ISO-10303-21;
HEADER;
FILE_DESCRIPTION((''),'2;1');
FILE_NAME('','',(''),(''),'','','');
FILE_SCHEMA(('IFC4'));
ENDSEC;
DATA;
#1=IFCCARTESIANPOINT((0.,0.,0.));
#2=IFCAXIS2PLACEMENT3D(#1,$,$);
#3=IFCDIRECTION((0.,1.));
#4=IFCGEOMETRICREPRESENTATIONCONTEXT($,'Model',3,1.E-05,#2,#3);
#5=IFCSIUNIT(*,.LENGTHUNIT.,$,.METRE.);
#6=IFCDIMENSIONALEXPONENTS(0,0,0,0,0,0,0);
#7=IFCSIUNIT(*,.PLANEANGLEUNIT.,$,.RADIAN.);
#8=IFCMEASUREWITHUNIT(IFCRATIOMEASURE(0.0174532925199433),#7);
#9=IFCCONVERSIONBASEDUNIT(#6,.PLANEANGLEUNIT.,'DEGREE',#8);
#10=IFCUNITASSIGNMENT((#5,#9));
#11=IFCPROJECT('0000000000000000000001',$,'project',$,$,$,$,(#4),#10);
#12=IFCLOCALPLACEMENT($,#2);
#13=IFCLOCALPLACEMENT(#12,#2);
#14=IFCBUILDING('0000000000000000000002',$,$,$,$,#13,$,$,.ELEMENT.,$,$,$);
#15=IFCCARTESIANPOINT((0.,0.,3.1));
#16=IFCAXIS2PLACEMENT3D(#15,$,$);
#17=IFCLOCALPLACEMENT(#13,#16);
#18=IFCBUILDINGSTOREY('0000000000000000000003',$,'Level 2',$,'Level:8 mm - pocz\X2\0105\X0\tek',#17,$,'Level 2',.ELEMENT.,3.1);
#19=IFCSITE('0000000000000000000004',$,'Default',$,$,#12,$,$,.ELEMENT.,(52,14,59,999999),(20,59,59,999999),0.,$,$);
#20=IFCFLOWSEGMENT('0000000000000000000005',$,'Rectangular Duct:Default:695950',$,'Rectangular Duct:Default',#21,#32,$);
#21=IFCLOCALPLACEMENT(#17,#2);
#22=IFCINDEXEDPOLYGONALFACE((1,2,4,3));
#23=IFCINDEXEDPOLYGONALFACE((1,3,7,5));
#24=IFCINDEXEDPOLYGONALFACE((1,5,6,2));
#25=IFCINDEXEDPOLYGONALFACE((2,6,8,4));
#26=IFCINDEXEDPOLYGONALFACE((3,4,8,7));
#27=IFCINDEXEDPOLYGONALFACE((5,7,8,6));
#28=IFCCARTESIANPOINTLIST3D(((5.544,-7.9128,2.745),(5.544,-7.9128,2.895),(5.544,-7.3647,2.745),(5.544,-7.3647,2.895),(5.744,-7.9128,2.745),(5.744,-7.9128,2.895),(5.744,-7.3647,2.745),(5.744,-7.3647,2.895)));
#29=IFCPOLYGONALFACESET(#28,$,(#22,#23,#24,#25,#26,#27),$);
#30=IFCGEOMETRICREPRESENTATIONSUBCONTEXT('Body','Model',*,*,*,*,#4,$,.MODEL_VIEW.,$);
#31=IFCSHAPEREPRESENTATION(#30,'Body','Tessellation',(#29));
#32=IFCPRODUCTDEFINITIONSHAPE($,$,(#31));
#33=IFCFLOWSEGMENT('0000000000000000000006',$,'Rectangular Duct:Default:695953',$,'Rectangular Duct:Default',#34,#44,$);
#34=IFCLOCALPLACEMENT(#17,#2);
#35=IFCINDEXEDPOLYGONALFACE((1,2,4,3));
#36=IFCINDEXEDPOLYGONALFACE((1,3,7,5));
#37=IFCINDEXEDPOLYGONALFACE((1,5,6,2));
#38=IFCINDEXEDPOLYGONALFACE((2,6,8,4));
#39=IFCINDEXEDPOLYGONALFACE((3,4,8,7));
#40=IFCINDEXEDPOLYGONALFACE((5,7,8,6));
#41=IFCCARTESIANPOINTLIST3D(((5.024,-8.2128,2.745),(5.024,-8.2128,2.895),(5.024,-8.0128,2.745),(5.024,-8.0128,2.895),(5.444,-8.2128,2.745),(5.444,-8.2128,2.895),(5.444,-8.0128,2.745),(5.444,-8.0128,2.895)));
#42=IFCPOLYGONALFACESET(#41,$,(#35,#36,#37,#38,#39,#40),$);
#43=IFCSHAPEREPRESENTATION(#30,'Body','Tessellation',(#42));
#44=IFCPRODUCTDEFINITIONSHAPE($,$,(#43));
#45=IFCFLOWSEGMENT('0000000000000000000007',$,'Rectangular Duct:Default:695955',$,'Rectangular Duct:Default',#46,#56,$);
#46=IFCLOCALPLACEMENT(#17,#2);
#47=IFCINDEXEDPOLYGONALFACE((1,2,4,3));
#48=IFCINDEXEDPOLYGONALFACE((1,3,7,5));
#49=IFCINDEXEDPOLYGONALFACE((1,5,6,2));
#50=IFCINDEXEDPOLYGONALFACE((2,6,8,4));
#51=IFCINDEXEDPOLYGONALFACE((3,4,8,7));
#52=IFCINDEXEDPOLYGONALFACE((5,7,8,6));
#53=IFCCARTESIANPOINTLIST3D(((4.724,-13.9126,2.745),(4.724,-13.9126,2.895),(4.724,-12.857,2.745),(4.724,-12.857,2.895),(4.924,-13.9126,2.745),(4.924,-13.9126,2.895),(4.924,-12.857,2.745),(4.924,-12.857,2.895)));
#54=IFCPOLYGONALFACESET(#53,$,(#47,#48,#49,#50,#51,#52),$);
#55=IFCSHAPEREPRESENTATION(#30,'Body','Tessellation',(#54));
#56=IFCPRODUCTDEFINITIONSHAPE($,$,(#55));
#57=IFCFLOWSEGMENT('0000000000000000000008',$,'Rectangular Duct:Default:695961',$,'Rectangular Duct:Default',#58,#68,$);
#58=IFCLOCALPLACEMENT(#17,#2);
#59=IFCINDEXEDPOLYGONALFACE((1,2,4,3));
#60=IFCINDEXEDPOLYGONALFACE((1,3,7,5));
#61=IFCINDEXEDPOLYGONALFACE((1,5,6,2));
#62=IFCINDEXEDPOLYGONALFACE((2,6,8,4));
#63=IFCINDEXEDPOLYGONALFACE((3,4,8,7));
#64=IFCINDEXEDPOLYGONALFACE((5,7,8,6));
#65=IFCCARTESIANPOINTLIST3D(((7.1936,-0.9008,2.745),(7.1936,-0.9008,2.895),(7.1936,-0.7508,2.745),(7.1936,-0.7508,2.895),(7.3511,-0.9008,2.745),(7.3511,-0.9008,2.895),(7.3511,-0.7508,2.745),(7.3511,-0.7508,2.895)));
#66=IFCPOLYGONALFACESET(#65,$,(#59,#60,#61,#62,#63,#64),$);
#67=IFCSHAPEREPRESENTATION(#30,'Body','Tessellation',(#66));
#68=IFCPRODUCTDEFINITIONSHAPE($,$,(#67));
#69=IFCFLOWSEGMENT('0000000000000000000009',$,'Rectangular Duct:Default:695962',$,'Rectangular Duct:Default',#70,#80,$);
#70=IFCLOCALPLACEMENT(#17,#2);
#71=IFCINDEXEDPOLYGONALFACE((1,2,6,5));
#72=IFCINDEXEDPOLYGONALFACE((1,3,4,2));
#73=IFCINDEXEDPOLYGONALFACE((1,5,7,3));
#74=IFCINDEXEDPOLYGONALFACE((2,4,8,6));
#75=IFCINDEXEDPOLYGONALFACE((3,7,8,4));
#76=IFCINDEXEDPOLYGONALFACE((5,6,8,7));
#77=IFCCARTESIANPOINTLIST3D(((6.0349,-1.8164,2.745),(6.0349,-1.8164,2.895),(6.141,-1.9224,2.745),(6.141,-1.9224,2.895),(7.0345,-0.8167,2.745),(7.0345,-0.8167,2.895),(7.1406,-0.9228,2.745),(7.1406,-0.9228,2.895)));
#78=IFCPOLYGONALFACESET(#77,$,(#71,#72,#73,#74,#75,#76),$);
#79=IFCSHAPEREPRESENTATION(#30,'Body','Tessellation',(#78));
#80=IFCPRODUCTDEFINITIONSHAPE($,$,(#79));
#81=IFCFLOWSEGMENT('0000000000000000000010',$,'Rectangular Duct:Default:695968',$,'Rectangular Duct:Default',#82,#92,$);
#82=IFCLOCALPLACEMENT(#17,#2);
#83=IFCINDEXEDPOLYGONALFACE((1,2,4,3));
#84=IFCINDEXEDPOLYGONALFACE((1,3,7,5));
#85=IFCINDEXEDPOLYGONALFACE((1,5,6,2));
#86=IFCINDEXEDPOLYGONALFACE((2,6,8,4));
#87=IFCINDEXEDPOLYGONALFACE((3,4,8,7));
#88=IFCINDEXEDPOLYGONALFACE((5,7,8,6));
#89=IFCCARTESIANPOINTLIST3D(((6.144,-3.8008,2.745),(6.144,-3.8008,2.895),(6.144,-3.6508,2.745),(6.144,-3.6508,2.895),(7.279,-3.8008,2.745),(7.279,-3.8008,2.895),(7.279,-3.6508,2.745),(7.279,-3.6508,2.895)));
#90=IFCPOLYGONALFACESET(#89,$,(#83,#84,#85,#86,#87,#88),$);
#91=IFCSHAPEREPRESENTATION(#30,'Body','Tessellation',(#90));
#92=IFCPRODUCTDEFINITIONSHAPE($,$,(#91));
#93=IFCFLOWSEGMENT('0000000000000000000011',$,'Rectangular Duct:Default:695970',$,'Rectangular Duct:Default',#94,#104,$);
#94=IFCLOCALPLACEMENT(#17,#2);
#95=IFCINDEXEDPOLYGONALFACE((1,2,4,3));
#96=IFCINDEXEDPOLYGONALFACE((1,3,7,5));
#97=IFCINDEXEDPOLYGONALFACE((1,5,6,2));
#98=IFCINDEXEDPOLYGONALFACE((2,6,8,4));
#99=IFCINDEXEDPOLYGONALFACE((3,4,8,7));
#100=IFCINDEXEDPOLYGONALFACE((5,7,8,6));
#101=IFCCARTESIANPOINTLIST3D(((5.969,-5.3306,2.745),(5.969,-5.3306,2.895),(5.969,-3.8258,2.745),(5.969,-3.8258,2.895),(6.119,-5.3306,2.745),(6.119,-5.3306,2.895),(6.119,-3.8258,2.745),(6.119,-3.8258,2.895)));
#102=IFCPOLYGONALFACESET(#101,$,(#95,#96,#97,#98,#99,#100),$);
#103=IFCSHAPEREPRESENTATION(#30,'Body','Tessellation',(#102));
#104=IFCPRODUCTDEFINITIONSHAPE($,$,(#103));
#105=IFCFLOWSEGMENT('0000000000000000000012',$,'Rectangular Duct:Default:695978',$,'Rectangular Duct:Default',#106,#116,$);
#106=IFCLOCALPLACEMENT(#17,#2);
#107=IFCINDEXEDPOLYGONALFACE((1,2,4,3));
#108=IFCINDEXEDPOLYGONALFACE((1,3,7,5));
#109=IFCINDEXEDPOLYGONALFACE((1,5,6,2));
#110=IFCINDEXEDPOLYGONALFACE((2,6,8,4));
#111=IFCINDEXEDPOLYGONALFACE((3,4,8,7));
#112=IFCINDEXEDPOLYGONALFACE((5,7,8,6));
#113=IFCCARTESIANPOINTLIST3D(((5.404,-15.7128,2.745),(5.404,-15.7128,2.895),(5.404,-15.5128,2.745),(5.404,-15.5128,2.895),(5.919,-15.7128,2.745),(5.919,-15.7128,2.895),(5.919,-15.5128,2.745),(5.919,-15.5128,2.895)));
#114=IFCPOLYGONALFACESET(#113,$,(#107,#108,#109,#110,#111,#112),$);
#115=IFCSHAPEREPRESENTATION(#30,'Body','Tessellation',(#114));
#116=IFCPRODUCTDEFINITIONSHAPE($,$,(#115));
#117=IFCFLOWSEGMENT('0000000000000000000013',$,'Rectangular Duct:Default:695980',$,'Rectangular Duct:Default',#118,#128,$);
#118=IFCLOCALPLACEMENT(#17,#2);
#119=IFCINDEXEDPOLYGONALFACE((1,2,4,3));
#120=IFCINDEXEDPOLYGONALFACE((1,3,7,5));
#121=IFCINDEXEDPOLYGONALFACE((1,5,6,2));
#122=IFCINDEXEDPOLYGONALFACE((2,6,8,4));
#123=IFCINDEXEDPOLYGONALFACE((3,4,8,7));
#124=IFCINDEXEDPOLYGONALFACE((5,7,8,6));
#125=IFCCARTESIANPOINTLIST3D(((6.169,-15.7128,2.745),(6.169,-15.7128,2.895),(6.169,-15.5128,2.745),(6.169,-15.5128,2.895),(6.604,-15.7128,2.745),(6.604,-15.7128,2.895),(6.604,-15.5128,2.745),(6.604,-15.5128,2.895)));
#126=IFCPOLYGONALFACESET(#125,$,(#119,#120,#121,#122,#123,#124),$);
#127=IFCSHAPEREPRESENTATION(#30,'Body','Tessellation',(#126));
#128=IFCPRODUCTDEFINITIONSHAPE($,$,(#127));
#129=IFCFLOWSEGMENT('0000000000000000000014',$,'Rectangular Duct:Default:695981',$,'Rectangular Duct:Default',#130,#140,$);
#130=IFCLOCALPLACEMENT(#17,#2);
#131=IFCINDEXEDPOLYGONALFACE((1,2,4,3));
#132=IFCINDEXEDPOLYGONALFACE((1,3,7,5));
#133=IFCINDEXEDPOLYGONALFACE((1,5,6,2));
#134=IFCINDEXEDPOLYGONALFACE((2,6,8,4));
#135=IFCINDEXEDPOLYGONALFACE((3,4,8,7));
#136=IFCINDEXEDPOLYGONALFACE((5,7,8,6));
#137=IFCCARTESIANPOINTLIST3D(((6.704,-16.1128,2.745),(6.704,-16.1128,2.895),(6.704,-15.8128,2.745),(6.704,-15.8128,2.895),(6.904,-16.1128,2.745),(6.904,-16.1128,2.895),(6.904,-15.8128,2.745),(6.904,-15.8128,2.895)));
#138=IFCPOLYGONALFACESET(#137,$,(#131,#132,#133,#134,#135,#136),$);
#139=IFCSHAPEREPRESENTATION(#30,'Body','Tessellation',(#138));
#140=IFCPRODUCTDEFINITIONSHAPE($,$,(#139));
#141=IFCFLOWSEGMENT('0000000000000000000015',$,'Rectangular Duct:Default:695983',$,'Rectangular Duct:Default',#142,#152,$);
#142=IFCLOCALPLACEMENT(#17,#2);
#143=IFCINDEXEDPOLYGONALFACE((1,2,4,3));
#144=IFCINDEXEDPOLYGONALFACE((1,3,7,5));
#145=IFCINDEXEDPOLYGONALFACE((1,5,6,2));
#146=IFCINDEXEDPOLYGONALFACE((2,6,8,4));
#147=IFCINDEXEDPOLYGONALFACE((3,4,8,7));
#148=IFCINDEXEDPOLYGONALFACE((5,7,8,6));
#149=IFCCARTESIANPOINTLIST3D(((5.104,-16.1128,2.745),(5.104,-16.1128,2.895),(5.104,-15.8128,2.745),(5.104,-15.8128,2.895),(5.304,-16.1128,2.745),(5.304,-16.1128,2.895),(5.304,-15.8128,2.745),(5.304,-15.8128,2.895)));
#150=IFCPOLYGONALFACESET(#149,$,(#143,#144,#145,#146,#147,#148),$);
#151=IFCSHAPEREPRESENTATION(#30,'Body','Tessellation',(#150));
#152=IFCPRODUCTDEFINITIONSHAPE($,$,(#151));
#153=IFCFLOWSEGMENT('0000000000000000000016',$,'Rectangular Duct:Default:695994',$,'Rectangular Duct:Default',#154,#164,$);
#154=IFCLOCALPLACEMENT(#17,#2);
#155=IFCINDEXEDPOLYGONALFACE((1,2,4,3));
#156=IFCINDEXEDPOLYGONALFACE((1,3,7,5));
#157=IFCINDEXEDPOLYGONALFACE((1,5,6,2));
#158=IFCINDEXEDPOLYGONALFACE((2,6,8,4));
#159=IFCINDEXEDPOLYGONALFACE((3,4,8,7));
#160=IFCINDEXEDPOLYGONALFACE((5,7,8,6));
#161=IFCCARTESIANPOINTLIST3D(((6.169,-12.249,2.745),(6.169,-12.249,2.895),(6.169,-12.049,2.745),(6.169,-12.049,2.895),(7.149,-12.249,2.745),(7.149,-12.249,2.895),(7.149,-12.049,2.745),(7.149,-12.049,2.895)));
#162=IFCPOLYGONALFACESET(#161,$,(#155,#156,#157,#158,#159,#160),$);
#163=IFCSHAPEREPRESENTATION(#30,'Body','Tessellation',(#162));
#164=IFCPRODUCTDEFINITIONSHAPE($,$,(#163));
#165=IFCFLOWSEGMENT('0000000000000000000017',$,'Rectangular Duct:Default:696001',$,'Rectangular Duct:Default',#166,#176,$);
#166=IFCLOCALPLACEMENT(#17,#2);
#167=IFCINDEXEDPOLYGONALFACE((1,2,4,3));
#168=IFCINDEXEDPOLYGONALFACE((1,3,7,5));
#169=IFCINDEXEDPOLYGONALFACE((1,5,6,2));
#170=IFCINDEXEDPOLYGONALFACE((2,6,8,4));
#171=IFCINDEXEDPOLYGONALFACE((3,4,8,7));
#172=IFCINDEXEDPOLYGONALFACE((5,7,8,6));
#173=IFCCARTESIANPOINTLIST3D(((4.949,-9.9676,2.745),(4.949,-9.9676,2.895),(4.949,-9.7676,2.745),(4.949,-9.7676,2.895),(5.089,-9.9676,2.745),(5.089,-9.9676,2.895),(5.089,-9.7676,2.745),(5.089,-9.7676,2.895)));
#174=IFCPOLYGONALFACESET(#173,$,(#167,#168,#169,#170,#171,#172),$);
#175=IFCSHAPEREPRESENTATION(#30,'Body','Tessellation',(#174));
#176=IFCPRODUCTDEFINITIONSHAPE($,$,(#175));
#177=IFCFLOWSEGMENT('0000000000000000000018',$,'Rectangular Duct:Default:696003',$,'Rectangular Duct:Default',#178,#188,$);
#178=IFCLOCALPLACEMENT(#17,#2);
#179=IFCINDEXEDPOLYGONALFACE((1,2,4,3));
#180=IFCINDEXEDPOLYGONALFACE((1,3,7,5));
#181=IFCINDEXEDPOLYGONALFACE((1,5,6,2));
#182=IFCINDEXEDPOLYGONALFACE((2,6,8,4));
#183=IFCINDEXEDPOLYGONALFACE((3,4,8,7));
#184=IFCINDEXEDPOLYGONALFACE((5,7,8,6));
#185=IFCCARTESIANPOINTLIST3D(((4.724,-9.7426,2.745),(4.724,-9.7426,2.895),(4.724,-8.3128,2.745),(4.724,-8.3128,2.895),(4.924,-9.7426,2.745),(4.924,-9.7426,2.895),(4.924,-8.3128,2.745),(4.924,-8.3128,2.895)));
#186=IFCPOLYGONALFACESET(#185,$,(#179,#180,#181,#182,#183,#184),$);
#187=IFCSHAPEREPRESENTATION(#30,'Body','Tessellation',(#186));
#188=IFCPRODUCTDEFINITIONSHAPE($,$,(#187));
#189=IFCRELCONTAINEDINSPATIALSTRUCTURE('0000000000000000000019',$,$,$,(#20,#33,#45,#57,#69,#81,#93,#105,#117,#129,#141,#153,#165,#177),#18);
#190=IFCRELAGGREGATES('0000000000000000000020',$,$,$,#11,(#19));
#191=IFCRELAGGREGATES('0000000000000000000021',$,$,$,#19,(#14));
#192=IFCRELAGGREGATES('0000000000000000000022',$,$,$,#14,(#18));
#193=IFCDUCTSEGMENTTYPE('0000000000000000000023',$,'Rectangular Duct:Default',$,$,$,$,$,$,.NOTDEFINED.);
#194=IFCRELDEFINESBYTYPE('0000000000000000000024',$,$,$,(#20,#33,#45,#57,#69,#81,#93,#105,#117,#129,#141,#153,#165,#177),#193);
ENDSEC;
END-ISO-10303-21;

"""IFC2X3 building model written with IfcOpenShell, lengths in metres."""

from ifc_helpers import new_model, entity, si_unit, converted_unit, direction, frame, frame_2d, origin, origin_2d_with_axis, place, context, subcontext, project, spatial, rectangle, extrude, type_object, element, save


model = new_model("IFC2X3")

# Units and contexts
model_context = context("Model", 3, precision=1e-05, world=origin(), true_north=direction((0.0, 1.0)))
body_context = subcontext(model_context, "Body", "Model", "MODEL_VIEW")
ifc_project = project(units=[si_unit("LENGTHUNIT", "METRE"), converted_unit("PLANEANGLEUNIT", "DEGREE", entity("IfcRatioMeasure", 0.0174532925199433), si_unit("PLANEANGLEUNIT", "RADIAN"), dimensions=[0, 0, 0, 0, 0, 0, 0])], contexts=[model_context])

# Site, building, storey
site_placement = place(None, origin())
site = spatial("IfcSite", under=ifc_project, at=site_placement, Name="Default", CompositionType="ELEMENT", RefLatitude=(52, 14, 59, 999999), RefLongitude=(20, 59, 59, 999999), RefElevation=0.0)
building_placement = place(site_placement, origin())
building = spatial("IfcBuilding", under=site, at=building_placement, CompositionType="ELEMENT")
storey_placement = place(building_placement, frame((0.0, 0.0, 3.1)))
storey = spatial("IfcBuildingStorey", under=building, at=storey_placement, Name="Level 2", ObjectType="Level:8 mm - początek", LongName="Level 2", CompositionType="ELEMENT", Elevation=3.1)

# Flow segments
duct_segment_type = type_object("IfcDuctSegmentType", Name="Rectangular Duct:Default", PredefinedType="NOTDEFINED")
flow_segment_1_placement = place(storey_placement, origin())
element("IfcFlowSegment", 1, at=flow_segment_1_placement, inside=storey, type_object=duct_segment_type, Name="Rectangular Duct:Default:695950", ObjectType="Rectangular Duct:Default", context=body_context, shape_type="SweptSolid", body=[
    extrude(rectangle(XDim=0.5481, YDim=0.2, at=frame_2d((0.0, 0.0), x_axis=(1.0, 0.0))), frame((5.644, -7.6388, 2.745), z_axis=(0.0, 0.0, 1.0), x_axis=(0.0, -1.0, 0.0)), (0.0, 0.0, 1.0), 0.15),
])
flow_segment_2_placement = place(storey_placement, origin())
element("IfcFlowSegment", 2, at=flow_segment_2_placement, inside=storey, type_object=duct_segment_type, Name="Rectangular Duct:Default:695953", ObjectType="Rectangular Duct:Default", context=body_context, shape_type="SweptSolid", body=[
    extrude(rectangle(XDim=0.42, YDim=0.2, at=origin_2d_with_axis()), frame((5.234, -8.1128, 2.745), z_axis=(0.0, 0.0, 1.0), x_axis=(-1.0, 0.0, 0.0)), (0.0, 0.0, 1.0), 0.15),
])
flow_segment_3_placement = place(storey_placement, origin())
element("IfcFlowSegment", 3, at=flow_segment_3_placement, inside=storey, type_object=duct_segment_type, Name="Rectangular Duct:Default:695955", ObjectType="Rectangular Duct:Default", context=body_context, shape_type="SweptSolid", body=[
    extrude(rectangle(XDim=1.0556, YDim=0.2, at=frame_2d((0.0, 0.0), x_axis=(1.0, 0.0))), frame((4.824, -13.3848, 2.745), z_axis=(0.0, 0.0, 1.0), x_axis=(0.0, -1.0, 0.0)), (0.0, 0.0, 1.0), 0.15),
])
flow_segment_4_placement = place(storey_placement, origin())
element("IfcFlowSegment", 4, at=flow_segment_4_placement, inside=storey, type_object=duct_segment_type, Name="Rectangular Duct:Default:695961", ObjectType="Rectangular Duct:Default", context=body_context, shape_type="SweptSolid", body=[
    extrude(rectangle(XDim=0.1575, YDim=0.15, at=frame_2d((0.0, 0.0), x_axis=(1.0, 0.0))), frame((7.2724, -0.8258, 2.745)), (0.0, 0.0, 1.0), 0.15),
])
flow_segment_5_placement = place(storey_placement, origin())
element("IfcFlowSegment", 5, at=flow_segment_5_placement, inside=storey, type_object=duct_segment_type, Name="Rectangular Duct:Default:695962", ObjectType="Rectangular Duct:Default", context=body_context, shape_type="SweptSolid", body=[
    extrude(rectangle(XDim=1.4137, YDim=0.15, at=frame_2d((0.0, 0.0), x_axis=(1.0, 0.0))), frame((6.5877, -1.3696, 2.745), z_axis=(0.0, 0.0, 1.0), x_axis=(0.707107, 0.707107, 0.0)), (0.0, 0.0, 1.0), 0.15),
])
flow_segment_6_placement = place(storey_placement, origin())
element("IfcFlowSegment", 6, at=flow_segment_6_placement, inside=storey, type_object=duct_segment_type, Name="Rectangular Duct:Default:695968", ObjectType="Rectangular Duct:Default", context=body_context, shape_type="SweptSolid", body=[
    extrude(rectangle(XDim=1.135, YDim=0.15, at=frame_2d((0.0, 0.0), x_axis=(1.0, 0.0))), frame((6.7115, -3.7258, 2.745)), (0.0, 0.0, 1.0), 0.15),
])
flow_segment_7_placement = place(storey_placement, origin())
element("IfcFlowSegment", 7, at=flow_segment_7_placement, inside=storey, type_object=duct_segment_type, Name="Rectangular Duct:Default:695970", ObjectType="Rectangular Duct:Default", context=body_context, shape_type="SweptSolid", body=[
    extrude(rectangle(XDim=1.5048, YDim=0.15, at=frame_2d((0.0, 0.0), x_axis=(1.0, 0.0))), frame((6.044, -4.5782, 2.745), z_axis=(0.0, 0.0, 1.0), x_axis=(0.0, 1.0, 0.0)), (0.0, 0.0, 1.0), 0.15),
])
flow_segment_8_placement = place(storey_placement, origin())
element("IfcFlowSegment", 8, at=flow_segment_8_placement, inside=storey, type_object=duct_segment_type, Name="Rectangular Duct:Default:695978", ObjectType="Rectangular Duct:Default", context=body_context, shape_type="SweptSolid", body=[
    extrude(rectangle(XDim=0.515, YDim=0.2, at=frame_2d((0.0, 0.0), x_axis=(1.0, 0.0))), frame((5.6615, -15.6128, 2.745), z_axis=(0.0, 0.0, 1.0), x_axis=(-1.0, 0.0, 0.0)), (0.0, 0.0, 1.0), 0.15),
])
flow_segment_9_placement = place(storey_placement, origin())
element("IfcFlowSegment", 9, at=flow_segment_9_placement, inside=storey, type_object=duct_segment_type, Name="Rectangular Duct:Default:695980", ObjectType="Rectangular Duct:Default", context=body_context, shape_type="SweptSolid", body=[
    extrude(rectangle(XDim=0.435, YDim=0.2, at=frame_2d((0.0, 0.0), x_axis=(1.0, 0.0))), frame((6.3865, -15.6128, 2.745), z_axis=(0.0, 0.0, 1.0), x_axis=(-1.0, 0.0, 0.0)), (0.0, 0.0, 1.0), 0.15),
])
flow_segment_10_placement = place(storey_placement, origin())
element("IfcFlowSegment", 10, at=flow_segment_10_placement, inside=storey, type_object=duct_segment_type, Name="Rectangular Duct:Default:695981", ObjectType="Rectangular Duct:Default", context=body_context, shape_type="SweptSolid", body=[
    extrude(rectangle(XDim=0.3, YDim=0.2, at=frame_2d((0.0, 0.0), x_axis=(1.0, 0.0))), frame((6.804, -15.9628, 2.745), z_axis=(0.0, 0.0, 1.0), x_axis=(0.0, -1.0, 0.0)), (0.0, 0.0, 1.0), 0.15),
])
flow_segment_11_placement = place(storey_placement, origin())
element("IfcFlowSegment", 11, at=flow_segment_11_placement, inside=storey, type_object=duct_segment_type, Name="Rectangular Duct:Default:695983", ObjectType="Rectangular Duct:Default", context=body_context, shape_type="SweptSolid", body=[
    extrude(rectangle(XDim=0.3, YDim=0.2, at=frame_2d((0.0, 0.0), x_axis=(1.0, 0.0))), frame((5.204, -15.9628, 2.745), z_axis=(0.0, 0.0, 1.0), x_axis=(0.0, -1.0, 0.0)), (0.0, 0.0, 1.0), 0.15),
])
flow_segment_12_placement = place(storey_placement, origin())
element("IfcFlowSegment", 12, at=flow_segment_12_placement, inside=storey, type_object=duct_segment_type, Name="Rectangular Duct:Default:695994", ObjectType="Rectangular Duct:Default", context=body_context, shape_type="SweptSolid", body=[
    extrude(rectangle(XDim=0.98, YDim=0.2, at=origin_2d_with_axis()), frame((6.659, -12.149, 2.745)), (0.0, 0.0, 1.0), 0.15),
])
flow_segment_13_placement = place(storey_placement, origin())
element("IfcFlowSegment", 13, at=flow_segment_13_placement, inside=storey, type_object=duct_segment_type, Name="Rectangular Duct:Default:696001", ObjectType="Rectangular Duct:Default", context=body_context, shape_type="SweptSolid", body=[
    extrude(rectangle(XDim=0.14, YDim=0.2, at=frame_2d((0.0, 0.0), x_axis=(1.0, 0.0))), frame((5.019, -9.8676, 2.745)), (0.0, 0.0, 1.0), 0.15),
])
flow_segment_14_placement = place(storey_placement, origin())
element("IfcFlowSegment", 14, at=flow_segment_14_placement, inside=storey, type_object=duct_segment_type, Name="Rectangular Duct:Default:696003", ObjectType="Rectangular Duct:Default", context=body_context, shape_type="SweptSolid", body=[
    extrude(rectangle(XDim=1.4298, YDim=0.2, at=origin_2d_with_axis()), frame((4.824, -9.0277, 2.745), z_axis=(0.0, 0.0, 1.0), x_axis=(0.0, -1.0, 0.0)), (0.0, 0.0, 1.0), 0.15),
])

save(model, "model.ifc")
